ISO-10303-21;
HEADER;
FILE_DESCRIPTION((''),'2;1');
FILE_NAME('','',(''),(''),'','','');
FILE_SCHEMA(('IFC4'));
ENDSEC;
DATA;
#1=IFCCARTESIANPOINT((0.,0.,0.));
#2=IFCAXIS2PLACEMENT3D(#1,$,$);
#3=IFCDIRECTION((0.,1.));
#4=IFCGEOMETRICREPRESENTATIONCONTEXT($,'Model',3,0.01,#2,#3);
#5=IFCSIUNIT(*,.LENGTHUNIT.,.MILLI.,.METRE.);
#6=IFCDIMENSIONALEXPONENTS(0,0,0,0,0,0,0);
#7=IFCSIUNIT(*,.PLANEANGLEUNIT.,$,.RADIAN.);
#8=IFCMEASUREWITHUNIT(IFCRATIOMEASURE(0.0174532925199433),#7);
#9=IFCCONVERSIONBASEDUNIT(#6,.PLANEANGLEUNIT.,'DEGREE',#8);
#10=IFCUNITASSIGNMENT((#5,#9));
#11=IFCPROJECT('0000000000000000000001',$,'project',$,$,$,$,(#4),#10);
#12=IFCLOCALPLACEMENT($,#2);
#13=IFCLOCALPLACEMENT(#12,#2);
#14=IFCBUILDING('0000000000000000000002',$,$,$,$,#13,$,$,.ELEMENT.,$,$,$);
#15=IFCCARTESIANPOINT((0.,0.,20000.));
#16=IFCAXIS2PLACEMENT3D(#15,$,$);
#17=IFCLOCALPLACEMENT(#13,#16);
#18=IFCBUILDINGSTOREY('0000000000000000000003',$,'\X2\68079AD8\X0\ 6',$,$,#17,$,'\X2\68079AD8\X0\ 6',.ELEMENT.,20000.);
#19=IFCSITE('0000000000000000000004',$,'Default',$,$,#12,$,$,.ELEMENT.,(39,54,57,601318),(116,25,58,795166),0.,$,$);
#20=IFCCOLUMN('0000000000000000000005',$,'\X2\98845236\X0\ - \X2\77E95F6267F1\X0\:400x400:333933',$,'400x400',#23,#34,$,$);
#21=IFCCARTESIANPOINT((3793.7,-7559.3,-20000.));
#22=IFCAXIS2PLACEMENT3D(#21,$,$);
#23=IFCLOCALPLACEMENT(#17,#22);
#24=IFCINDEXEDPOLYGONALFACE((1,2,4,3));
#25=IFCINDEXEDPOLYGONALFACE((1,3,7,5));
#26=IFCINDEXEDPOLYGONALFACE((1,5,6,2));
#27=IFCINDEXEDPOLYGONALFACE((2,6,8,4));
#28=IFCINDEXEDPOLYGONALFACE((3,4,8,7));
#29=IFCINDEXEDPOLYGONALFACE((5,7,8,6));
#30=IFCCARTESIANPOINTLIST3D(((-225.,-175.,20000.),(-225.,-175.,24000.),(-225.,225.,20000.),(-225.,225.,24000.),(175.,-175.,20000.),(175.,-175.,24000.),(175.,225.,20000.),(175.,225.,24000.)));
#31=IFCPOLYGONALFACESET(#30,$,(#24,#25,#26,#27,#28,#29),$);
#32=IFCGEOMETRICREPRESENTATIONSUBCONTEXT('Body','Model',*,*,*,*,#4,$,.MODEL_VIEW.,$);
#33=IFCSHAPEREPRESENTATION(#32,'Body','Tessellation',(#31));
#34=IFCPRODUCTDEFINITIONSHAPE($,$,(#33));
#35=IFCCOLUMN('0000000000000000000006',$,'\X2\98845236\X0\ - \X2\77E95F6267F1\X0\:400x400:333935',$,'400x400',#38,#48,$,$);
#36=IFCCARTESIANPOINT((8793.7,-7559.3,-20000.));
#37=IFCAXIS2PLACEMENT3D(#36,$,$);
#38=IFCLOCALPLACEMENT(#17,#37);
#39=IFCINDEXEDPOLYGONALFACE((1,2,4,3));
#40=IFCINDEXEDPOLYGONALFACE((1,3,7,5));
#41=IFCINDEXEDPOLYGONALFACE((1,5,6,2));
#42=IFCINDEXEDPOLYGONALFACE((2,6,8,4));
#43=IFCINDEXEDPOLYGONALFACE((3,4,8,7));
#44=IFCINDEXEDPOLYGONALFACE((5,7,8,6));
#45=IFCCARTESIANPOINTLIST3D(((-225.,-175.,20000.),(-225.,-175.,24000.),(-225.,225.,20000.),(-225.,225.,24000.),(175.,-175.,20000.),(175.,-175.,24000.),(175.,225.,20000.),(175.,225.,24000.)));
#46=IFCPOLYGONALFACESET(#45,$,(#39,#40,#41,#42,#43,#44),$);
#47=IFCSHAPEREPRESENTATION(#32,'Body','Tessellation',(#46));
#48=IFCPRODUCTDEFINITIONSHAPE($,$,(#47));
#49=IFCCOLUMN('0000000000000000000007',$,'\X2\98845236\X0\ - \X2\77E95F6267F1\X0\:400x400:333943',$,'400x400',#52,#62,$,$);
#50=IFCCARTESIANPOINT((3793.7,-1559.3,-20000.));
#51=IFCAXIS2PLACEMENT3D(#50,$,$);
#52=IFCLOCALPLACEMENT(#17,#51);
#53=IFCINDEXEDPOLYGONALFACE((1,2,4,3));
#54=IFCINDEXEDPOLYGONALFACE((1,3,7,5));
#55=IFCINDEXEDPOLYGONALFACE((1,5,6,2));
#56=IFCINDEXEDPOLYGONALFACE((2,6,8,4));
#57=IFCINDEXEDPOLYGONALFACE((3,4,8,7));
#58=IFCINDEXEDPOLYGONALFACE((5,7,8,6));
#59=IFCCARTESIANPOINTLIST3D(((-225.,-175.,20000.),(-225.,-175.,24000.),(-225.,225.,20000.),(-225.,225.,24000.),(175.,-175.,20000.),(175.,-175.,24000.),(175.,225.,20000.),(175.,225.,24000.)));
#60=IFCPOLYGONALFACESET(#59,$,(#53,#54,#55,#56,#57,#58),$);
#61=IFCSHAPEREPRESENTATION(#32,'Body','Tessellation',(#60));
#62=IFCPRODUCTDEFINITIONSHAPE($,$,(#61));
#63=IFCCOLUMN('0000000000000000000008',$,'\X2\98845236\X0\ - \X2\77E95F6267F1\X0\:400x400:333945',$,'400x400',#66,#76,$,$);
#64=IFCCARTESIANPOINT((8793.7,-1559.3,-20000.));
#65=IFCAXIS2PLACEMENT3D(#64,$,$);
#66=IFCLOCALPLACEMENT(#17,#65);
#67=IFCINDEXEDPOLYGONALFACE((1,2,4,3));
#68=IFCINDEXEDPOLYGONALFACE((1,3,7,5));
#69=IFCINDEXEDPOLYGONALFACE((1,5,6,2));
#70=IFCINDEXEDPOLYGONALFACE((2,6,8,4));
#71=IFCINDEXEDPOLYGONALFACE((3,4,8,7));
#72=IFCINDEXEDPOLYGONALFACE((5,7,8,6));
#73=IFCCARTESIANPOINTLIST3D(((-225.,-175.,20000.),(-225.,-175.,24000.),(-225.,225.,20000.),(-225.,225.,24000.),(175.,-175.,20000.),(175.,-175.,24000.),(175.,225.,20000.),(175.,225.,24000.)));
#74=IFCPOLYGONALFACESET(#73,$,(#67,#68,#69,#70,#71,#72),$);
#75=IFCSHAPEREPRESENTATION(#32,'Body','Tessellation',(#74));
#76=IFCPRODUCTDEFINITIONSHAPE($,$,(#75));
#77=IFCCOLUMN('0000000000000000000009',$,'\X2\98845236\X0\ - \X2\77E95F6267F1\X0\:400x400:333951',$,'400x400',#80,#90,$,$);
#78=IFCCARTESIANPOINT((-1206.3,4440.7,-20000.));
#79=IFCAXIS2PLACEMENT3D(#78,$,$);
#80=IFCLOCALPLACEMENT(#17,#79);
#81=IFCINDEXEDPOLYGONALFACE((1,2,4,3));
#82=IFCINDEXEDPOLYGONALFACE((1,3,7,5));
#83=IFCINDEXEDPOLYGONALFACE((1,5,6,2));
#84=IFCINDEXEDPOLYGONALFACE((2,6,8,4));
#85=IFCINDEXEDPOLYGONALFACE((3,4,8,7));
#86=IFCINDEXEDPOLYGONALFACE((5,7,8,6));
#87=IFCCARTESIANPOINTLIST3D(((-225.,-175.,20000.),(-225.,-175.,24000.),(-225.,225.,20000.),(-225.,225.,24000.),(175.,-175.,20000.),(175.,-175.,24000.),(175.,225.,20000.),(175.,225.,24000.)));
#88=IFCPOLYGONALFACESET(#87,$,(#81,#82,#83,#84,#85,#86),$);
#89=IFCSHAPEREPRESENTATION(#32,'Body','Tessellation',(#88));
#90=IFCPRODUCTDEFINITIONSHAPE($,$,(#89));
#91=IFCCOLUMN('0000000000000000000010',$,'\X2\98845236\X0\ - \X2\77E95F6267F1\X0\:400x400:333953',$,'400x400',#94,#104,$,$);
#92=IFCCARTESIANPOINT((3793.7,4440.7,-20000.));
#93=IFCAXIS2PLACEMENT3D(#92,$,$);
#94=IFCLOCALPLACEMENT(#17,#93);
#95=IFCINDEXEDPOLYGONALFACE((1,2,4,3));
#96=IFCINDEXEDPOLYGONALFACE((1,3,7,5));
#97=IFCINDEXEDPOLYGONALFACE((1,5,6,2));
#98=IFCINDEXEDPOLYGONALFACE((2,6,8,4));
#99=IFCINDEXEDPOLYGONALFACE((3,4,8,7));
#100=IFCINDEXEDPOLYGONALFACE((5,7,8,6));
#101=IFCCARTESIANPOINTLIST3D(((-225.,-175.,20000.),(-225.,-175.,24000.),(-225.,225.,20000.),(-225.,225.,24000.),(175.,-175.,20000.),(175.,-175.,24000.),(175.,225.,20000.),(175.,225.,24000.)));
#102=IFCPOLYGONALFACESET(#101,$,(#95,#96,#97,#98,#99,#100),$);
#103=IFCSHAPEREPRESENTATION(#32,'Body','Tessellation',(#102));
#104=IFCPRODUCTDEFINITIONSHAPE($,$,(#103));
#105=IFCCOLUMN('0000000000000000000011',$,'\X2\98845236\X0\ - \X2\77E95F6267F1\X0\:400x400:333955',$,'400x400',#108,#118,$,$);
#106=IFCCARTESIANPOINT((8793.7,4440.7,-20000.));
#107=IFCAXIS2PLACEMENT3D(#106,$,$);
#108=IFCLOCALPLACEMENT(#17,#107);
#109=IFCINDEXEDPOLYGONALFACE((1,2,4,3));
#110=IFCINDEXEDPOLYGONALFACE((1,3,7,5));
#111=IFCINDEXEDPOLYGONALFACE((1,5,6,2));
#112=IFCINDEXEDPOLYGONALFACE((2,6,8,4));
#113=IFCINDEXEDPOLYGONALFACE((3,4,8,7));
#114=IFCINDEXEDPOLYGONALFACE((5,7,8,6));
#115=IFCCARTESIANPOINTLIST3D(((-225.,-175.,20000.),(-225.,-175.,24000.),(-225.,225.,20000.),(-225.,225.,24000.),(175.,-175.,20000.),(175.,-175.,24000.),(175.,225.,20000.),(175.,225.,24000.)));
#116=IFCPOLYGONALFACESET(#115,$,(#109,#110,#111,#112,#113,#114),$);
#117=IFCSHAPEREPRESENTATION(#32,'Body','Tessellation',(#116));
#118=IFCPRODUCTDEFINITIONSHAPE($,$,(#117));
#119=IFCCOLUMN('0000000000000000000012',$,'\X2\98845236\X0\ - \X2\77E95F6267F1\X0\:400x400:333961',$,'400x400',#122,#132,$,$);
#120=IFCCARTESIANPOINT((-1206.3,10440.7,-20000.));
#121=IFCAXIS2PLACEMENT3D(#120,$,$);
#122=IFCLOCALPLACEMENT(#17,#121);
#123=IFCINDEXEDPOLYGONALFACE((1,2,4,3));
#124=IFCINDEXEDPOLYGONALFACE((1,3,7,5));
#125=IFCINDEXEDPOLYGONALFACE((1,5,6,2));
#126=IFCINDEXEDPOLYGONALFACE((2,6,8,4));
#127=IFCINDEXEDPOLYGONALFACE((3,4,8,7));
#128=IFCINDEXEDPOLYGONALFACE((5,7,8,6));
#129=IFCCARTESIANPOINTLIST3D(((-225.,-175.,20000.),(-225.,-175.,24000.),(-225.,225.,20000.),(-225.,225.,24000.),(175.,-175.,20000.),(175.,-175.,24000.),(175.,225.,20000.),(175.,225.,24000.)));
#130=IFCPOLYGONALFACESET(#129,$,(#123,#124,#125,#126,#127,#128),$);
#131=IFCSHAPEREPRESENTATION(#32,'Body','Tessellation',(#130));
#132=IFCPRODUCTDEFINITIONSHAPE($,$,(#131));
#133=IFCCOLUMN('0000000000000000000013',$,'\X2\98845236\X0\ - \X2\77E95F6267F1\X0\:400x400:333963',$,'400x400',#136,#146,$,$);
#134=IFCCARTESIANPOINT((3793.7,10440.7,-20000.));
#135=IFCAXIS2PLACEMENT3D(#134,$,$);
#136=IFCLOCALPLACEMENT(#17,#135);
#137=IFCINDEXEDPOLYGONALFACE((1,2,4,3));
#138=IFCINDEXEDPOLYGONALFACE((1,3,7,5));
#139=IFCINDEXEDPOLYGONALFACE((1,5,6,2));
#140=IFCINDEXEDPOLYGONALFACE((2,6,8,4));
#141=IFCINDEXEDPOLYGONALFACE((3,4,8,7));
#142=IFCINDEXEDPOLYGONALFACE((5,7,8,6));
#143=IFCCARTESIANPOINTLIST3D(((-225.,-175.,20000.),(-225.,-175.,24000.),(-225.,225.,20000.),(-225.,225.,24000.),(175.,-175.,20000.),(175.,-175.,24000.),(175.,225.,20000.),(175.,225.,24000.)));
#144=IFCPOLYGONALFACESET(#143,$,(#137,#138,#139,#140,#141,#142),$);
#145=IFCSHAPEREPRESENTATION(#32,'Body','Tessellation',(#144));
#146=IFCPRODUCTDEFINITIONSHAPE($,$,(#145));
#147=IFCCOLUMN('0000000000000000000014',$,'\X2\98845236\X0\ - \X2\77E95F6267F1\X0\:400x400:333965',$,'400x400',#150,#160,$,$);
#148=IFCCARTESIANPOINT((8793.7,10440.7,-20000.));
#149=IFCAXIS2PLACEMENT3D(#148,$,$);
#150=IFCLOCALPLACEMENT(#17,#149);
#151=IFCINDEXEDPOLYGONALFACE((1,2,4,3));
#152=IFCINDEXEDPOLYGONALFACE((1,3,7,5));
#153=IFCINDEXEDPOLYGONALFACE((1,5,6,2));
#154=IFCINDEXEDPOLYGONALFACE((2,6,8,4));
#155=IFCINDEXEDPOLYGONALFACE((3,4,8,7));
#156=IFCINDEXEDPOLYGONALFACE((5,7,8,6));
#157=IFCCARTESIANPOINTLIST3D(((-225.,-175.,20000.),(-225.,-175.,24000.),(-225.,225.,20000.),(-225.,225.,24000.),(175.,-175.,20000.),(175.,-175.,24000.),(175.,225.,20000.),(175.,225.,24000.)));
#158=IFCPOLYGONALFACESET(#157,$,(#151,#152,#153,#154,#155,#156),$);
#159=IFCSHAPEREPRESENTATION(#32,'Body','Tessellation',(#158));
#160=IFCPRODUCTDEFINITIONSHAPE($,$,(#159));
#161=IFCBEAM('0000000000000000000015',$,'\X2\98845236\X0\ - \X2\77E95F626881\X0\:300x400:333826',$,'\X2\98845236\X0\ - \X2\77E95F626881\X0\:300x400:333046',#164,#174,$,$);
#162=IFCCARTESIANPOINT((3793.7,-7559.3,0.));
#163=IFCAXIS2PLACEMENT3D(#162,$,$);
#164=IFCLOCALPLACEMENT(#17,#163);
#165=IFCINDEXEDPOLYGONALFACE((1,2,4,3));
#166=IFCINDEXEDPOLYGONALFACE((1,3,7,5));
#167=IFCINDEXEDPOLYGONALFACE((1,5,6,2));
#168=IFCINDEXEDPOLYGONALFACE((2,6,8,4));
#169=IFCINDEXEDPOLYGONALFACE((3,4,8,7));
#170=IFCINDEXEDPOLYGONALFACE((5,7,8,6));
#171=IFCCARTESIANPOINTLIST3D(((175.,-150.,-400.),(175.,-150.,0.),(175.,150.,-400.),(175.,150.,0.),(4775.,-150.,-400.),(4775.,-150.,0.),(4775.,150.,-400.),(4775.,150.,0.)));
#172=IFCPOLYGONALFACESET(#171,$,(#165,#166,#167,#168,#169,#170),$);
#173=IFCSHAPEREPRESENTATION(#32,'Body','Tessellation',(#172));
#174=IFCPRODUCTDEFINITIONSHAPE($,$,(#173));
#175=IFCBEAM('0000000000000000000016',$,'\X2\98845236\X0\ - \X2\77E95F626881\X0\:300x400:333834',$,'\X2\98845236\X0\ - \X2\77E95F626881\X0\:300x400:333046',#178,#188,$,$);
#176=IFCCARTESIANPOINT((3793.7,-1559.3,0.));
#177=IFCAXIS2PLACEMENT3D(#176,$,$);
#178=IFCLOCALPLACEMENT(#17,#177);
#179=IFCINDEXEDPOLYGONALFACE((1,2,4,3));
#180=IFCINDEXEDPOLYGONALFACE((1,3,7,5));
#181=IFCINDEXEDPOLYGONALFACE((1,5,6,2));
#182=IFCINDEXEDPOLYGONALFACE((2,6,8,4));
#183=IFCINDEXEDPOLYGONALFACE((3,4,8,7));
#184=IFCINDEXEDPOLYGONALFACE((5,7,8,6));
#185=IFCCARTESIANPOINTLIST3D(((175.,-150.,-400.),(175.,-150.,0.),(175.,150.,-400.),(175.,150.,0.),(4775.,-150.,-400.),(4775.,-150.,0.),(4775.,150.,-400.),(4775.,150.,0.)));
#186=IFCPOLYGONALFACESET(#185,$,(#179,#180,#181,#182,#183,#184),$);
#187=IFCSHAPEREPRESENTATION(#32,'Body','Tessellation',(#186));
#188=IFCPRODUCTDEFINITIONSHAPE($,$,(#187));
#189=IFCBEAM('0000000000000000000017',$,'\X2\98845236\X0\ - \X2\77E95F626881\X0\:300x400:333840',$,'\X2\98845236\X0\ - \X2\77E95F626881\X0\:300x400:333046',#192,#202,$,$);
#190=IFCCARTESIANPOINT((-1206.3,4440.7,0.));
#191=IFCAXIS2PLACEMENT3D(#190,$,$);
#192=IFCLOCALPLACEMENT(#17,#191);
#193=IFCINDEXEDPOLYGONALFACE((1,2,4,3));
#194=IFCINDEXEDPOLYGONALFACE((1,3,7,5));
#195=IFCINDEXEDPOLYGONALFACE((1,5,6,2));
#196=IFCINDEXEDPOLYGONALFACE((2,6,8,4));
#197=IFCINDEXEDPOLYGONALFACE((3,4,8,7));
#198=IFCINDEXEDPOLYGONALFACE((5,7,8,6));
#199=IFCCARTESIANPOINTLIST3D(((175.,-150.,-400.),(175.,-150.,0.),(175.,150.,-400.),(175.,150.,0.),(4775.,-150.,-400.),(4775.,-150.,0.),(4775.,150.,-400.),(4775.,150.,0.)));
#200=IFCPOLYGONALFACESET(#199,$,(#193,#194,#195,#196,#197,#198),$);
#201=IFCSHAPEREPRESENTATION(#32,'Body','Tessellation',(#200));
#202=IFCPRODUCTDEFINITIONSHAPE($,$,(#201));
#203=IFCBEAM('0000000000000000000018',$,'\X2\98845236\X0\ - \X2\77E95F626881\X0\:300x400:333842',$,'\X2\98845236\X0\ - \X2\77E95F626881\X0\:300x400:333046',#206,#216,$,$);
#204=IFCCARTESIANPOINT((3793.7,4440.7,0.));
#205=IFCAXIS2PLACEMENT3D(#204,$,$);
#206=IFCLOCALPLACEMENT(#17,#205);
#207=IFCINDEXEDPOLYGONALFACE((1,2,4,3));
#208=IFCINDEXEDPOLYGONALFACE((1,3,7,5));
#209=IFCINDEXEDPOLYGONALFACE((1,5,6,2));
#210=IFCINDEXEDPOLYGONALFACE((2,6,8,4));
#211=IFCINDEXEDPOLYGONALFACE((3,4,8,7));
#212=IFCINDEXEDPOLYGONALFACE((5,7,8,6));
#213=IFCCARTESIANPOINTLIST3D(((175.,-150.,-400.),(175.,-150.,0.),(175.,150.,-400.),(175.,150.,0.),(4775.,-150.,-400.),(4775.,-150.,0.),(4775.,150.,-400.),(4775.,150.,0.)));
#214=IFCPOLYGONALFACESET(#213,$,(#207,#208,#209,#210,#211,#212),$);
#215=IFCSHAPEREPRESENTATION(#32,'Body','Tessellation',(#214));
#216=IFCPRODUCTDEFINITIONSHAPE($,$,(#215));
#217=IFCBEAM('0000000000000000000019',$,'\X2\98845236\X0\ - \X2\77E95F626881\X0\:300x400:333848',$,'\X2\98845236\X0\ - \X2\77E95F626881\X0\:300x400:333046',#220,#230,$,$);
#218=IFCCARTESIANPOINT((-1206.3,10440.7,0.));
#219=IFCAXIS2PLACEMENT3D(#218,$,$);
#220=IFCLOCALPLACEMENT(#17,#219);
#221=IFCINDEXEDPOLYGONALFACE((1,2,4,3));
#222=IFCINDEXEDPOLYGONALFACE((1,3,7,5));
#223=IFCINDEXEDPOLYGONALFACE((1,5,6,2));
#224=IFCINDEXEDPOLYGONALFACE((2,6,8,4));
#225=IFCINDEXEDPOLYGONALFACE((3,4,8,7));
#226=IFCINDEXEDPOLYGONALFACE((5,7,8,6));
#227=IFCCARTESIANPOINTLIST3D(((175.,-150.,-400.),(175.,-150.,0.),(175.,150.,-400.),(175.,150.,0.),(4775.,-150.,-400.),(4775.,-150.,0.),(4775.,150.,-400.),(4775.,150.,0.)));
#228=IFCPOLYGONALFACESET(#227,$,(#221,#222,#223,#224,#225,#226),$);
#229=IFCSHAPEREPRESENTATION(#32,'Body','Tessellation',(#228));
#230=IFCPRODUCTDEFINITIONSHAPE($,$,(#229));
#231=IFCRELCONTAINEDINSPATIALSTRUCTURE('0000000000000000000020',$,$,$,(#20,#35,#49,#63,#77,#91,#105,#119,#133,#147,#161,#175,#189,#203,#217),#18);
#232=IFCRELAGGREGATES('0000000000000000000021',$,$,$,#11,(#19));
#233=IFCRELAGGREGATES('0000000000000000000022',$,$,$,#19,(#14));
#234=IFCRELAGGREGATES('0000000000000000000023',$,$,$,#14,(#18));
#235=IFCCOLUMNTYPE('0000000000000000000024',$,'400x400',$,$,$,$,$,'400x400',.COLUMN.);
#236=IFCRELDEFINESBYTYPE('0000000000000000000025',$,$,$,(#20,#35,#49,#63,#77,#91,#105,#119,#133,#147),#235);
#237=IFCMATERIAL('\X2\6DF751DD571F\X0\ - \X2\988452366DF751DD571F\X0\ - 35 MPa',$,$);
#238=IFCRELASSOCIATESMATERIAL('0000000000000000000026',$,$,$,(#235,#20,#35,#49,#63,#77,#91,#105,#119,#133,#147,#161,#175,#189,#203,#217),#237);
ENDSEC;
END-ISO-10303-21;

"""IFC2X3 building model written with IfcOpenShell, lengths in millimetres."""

from ifc_helpers import new_model, entity, si_unit, converted_unit, direction, frame, frame_2d, origin, place, context, subcontext, project, spatial, rectangle, extrude, source, transform, mapped, material, type_object, type_shapes, element, save


model = new_model("IFC2X3")

# Units and contexts
model_context = context("Model", 3, precision=0.01, world=origin(), true_north=direction((0.0, 1.0)))
body_context = subcontext(model_context, "Body", "Model", "MODEL_VIEW")
ifc_project = project(units=[si_unit("LENGTHUNIT", "METRE", prefix="MILLI"), converted_unit("PLANEANGLEUNIT", "DEGREE", entity("IfcRatioMeasure", 0.0174532925199433), si_unit("PLANEANGLEUNIT", "RADIAN"), dimensions=[0, 0, 0, 0, 0, 0, 0])], contexts=[model_context])

# Site, building, storey
site_placement = place(None, origin())
site = spatial("IfcSite", under=ifc_project, at=site_placement, Name="Default", CompositionType="ELEMENT", RefLatitude=(39, 54, 57, 601318), RefLongitude=(116, 25, 58, 795166), RefElevation=0.0)
building_placement = place(site_placement, origin())
building = spatial("IfcBuilding", under=site, at=building_placement, CompositionType="ELEMENT")
storey_placement = place(building_placement, frame((0.0, 0.0, 20000.0)))
storey = spatial("IfcBuildingStorey", under=building, at=storey_placement, Name="标高 6", LongName="标高 6", CompositionType="ELEMENT", Elevation=20000.0)

# Columns
ifc_material_1 = material(Name="混凝土 - 预制混凝土 - 35 MPa")
column_type = type_object("IfcColumnType", Name="400x400", ElementType="400x400", PredefinedType="COLUMN", material=ifc_material_1)
shared_shape = source(origin(), body_context, "Body", "SweptSolid", [
    extrude(rectangle(XDim=400.0, YDim=400.0, at=frame_2d((0.0, 0.0), x_axis=(1.0, 0.0))), frame((-25.0, 25.0, 20000.0)), (0.0, 0.0, 1.0), 4000.0),
])
type_shapes(column_type, [shared_shape])
for number, where, name in (
    (1, (3793.7, -7559.3, -20000.0), "预制 - 矩形柱:400x400:333933"),
    (2, (8793.7, -7559.3, -20000.0), "预制 - 矩形柱:400x400:333935"),
    (3, (3793.7, -1559.3, -20000.0), "预制 - 矩形柱:400x400:333943"),
    (4, (8793.7, -1559.3, -20000.0), "预制 - 矩形柱:400x400:333945"),
    (5, (-1206.3, 4440.7, -20000.0), "预制 - 矩形柱:400x400:333951"),
    (6, (3793.7, 4440.7, -20000.0), "预制 - 矩形柱:400x400:333953"),
    (7, (8793.7, 4440.7, -20000.0), "预制 - 矩形柱:400x400:333955"),
    (8, (-1206.3, 10440.7, -20000.0), "预制 - 矩形柱:400x400:333961"),
    (9, (3793.7, 10440.7, -20000.0), "预制 - 矩形柱:400x400:333963"),
    (10, (8793.7, 10440.7, -20000.0), "预制 - 矩形柱:400x400:333965"),
):
    element("IfcColumn", number, at=place(storey_placement, frame(where)), inside=storey, type_object=column_type, material=ifc_material_1, Name=name, ObjectType="400x400", context=body_context, shape_type="MappedRepresentation", body=[
        mapped(shared_shape, transform((0.0, 0.0, 0.0), scale=1.0)),
    ])

# Beams
beam_1_placement = place(storey_placement, frame((3793.7, -7559.3, 0.0)))
element("IfcBeam", 11, at=beam_1_placement, inside=storey, material=ifc_material_1, Name="预制 - 矩形梁:300x400:333826", ObjectType="预制 - 矩形梁:300x400:333046", context=body_context, shape_type="SweptSolid", body=[
    extrude(rectangle(XDim=400.0, YDim=300.0, at=frame_2d((0.0, 0.0), x_axis=(1.0, 0.0))), frame((175.0, 0.0, -200.0), z_axis=(1.0, 0.0, 0.0), x_axis=(0.0, 0.0, -1.0)), (0.0, 0.0, 1.0), 4600.0),
])
beam_2_placement = place(storey_placement, frame((3793.7, -1559.3, 0.0)))
element("IfcBeam", 12, at=beam_2_placement, inside=storey, material=ifc_material_1, Name="预制 - 矩形梁:300x400:333834", ObjectType="预制 - 矩形梁:300x400:333046", context=body_context, shape_type="SweptSolid", body=[
    extrude(rectangle(XDim=400.0, YDim=300.0, at=frame_2d((0.0, 0.0), x_axis=(1.0, 0.0))), frame((175.0, 0.0, -200.0), z_axis=(1.0, 0.0, 0.0), x_axis=(0.0, 0.0, -1.0)), (0.0, 0.0, 1.0), 4600.0),
])
beam_3_placement = place(storey_placement, frame((-1206.3, 4440.7, 0.0)))
element("IfcBeam", 13, at=beam_3_placement, inside=storey, material=ifc_material_1, Name="预制 - 矩形梁:300x400:333840", ObjectType="预制 - 矩形梁:300x400:333046", context=body_context, shape_type="SweptSolid", body=[
    extrude(rectangle(XDim=400.0, YDim=300.0, at=frame_2d((0.0, 0.0), x_axis=(1.0, 0.0))), frame((175.0, 0.0, -200.0), z_axis=(1.0, 0.0, 0.0), x_axis=(0.0, 0.0, -1.0)), (0.0, 0.0, 1.0), 4600.0),
])
beam_4_placement = place(storey_placement, frame((3793.7, 4440.7, 0.0)))
element("IfcBeam", 14, at=beam_4_placement, inside=storey, material=ifc_material_1, Name="预制 - 矩形梁:300x400:333842", ObjectType="预制 - 矩形梁:300x400:333046", context=body_context, shape_type="SweptSolid", body=[
    extrude(rectangle(XDim=400.0, YDim=300.0, at=frame_2d((0.0, 0.0), x_axis=(1.0, 0.0))), frame((175.0, 0.0, -200.0), z_axis=(1.0, 0.0, 0.0), x_axis=(0.0, 0.0, -1.0)), (0.0, 0.0, 1.0), 4600.0),
])
beam_5_placement = place(storey_placement, frame((-1206.3, 10440.7, 0.0)))
element("IfcBeam", 15, at=beam_5_placement, inside=storey, material=ifc_material_1, Name="预制 - 矩形梁:300x400:333848", ObjectType="预制 - 矩形梁:300x400:333046", context=body_context, shape_type="SweptSolid", body=[
    extrude(rectangle(XDim=400.0, YDim=300.0, at=frame_2d((0.0, 0.0), x_axis=(1.0, 0.0))), frame((175.0, 0.0, -200.0), z_axis=(1.0, 0.0, 0.0), x_axis=(0.0, 0.0, -1.0)), (0.0, 0.0, 1.0), 4600.0),
])

save(model, "model.ifc")
